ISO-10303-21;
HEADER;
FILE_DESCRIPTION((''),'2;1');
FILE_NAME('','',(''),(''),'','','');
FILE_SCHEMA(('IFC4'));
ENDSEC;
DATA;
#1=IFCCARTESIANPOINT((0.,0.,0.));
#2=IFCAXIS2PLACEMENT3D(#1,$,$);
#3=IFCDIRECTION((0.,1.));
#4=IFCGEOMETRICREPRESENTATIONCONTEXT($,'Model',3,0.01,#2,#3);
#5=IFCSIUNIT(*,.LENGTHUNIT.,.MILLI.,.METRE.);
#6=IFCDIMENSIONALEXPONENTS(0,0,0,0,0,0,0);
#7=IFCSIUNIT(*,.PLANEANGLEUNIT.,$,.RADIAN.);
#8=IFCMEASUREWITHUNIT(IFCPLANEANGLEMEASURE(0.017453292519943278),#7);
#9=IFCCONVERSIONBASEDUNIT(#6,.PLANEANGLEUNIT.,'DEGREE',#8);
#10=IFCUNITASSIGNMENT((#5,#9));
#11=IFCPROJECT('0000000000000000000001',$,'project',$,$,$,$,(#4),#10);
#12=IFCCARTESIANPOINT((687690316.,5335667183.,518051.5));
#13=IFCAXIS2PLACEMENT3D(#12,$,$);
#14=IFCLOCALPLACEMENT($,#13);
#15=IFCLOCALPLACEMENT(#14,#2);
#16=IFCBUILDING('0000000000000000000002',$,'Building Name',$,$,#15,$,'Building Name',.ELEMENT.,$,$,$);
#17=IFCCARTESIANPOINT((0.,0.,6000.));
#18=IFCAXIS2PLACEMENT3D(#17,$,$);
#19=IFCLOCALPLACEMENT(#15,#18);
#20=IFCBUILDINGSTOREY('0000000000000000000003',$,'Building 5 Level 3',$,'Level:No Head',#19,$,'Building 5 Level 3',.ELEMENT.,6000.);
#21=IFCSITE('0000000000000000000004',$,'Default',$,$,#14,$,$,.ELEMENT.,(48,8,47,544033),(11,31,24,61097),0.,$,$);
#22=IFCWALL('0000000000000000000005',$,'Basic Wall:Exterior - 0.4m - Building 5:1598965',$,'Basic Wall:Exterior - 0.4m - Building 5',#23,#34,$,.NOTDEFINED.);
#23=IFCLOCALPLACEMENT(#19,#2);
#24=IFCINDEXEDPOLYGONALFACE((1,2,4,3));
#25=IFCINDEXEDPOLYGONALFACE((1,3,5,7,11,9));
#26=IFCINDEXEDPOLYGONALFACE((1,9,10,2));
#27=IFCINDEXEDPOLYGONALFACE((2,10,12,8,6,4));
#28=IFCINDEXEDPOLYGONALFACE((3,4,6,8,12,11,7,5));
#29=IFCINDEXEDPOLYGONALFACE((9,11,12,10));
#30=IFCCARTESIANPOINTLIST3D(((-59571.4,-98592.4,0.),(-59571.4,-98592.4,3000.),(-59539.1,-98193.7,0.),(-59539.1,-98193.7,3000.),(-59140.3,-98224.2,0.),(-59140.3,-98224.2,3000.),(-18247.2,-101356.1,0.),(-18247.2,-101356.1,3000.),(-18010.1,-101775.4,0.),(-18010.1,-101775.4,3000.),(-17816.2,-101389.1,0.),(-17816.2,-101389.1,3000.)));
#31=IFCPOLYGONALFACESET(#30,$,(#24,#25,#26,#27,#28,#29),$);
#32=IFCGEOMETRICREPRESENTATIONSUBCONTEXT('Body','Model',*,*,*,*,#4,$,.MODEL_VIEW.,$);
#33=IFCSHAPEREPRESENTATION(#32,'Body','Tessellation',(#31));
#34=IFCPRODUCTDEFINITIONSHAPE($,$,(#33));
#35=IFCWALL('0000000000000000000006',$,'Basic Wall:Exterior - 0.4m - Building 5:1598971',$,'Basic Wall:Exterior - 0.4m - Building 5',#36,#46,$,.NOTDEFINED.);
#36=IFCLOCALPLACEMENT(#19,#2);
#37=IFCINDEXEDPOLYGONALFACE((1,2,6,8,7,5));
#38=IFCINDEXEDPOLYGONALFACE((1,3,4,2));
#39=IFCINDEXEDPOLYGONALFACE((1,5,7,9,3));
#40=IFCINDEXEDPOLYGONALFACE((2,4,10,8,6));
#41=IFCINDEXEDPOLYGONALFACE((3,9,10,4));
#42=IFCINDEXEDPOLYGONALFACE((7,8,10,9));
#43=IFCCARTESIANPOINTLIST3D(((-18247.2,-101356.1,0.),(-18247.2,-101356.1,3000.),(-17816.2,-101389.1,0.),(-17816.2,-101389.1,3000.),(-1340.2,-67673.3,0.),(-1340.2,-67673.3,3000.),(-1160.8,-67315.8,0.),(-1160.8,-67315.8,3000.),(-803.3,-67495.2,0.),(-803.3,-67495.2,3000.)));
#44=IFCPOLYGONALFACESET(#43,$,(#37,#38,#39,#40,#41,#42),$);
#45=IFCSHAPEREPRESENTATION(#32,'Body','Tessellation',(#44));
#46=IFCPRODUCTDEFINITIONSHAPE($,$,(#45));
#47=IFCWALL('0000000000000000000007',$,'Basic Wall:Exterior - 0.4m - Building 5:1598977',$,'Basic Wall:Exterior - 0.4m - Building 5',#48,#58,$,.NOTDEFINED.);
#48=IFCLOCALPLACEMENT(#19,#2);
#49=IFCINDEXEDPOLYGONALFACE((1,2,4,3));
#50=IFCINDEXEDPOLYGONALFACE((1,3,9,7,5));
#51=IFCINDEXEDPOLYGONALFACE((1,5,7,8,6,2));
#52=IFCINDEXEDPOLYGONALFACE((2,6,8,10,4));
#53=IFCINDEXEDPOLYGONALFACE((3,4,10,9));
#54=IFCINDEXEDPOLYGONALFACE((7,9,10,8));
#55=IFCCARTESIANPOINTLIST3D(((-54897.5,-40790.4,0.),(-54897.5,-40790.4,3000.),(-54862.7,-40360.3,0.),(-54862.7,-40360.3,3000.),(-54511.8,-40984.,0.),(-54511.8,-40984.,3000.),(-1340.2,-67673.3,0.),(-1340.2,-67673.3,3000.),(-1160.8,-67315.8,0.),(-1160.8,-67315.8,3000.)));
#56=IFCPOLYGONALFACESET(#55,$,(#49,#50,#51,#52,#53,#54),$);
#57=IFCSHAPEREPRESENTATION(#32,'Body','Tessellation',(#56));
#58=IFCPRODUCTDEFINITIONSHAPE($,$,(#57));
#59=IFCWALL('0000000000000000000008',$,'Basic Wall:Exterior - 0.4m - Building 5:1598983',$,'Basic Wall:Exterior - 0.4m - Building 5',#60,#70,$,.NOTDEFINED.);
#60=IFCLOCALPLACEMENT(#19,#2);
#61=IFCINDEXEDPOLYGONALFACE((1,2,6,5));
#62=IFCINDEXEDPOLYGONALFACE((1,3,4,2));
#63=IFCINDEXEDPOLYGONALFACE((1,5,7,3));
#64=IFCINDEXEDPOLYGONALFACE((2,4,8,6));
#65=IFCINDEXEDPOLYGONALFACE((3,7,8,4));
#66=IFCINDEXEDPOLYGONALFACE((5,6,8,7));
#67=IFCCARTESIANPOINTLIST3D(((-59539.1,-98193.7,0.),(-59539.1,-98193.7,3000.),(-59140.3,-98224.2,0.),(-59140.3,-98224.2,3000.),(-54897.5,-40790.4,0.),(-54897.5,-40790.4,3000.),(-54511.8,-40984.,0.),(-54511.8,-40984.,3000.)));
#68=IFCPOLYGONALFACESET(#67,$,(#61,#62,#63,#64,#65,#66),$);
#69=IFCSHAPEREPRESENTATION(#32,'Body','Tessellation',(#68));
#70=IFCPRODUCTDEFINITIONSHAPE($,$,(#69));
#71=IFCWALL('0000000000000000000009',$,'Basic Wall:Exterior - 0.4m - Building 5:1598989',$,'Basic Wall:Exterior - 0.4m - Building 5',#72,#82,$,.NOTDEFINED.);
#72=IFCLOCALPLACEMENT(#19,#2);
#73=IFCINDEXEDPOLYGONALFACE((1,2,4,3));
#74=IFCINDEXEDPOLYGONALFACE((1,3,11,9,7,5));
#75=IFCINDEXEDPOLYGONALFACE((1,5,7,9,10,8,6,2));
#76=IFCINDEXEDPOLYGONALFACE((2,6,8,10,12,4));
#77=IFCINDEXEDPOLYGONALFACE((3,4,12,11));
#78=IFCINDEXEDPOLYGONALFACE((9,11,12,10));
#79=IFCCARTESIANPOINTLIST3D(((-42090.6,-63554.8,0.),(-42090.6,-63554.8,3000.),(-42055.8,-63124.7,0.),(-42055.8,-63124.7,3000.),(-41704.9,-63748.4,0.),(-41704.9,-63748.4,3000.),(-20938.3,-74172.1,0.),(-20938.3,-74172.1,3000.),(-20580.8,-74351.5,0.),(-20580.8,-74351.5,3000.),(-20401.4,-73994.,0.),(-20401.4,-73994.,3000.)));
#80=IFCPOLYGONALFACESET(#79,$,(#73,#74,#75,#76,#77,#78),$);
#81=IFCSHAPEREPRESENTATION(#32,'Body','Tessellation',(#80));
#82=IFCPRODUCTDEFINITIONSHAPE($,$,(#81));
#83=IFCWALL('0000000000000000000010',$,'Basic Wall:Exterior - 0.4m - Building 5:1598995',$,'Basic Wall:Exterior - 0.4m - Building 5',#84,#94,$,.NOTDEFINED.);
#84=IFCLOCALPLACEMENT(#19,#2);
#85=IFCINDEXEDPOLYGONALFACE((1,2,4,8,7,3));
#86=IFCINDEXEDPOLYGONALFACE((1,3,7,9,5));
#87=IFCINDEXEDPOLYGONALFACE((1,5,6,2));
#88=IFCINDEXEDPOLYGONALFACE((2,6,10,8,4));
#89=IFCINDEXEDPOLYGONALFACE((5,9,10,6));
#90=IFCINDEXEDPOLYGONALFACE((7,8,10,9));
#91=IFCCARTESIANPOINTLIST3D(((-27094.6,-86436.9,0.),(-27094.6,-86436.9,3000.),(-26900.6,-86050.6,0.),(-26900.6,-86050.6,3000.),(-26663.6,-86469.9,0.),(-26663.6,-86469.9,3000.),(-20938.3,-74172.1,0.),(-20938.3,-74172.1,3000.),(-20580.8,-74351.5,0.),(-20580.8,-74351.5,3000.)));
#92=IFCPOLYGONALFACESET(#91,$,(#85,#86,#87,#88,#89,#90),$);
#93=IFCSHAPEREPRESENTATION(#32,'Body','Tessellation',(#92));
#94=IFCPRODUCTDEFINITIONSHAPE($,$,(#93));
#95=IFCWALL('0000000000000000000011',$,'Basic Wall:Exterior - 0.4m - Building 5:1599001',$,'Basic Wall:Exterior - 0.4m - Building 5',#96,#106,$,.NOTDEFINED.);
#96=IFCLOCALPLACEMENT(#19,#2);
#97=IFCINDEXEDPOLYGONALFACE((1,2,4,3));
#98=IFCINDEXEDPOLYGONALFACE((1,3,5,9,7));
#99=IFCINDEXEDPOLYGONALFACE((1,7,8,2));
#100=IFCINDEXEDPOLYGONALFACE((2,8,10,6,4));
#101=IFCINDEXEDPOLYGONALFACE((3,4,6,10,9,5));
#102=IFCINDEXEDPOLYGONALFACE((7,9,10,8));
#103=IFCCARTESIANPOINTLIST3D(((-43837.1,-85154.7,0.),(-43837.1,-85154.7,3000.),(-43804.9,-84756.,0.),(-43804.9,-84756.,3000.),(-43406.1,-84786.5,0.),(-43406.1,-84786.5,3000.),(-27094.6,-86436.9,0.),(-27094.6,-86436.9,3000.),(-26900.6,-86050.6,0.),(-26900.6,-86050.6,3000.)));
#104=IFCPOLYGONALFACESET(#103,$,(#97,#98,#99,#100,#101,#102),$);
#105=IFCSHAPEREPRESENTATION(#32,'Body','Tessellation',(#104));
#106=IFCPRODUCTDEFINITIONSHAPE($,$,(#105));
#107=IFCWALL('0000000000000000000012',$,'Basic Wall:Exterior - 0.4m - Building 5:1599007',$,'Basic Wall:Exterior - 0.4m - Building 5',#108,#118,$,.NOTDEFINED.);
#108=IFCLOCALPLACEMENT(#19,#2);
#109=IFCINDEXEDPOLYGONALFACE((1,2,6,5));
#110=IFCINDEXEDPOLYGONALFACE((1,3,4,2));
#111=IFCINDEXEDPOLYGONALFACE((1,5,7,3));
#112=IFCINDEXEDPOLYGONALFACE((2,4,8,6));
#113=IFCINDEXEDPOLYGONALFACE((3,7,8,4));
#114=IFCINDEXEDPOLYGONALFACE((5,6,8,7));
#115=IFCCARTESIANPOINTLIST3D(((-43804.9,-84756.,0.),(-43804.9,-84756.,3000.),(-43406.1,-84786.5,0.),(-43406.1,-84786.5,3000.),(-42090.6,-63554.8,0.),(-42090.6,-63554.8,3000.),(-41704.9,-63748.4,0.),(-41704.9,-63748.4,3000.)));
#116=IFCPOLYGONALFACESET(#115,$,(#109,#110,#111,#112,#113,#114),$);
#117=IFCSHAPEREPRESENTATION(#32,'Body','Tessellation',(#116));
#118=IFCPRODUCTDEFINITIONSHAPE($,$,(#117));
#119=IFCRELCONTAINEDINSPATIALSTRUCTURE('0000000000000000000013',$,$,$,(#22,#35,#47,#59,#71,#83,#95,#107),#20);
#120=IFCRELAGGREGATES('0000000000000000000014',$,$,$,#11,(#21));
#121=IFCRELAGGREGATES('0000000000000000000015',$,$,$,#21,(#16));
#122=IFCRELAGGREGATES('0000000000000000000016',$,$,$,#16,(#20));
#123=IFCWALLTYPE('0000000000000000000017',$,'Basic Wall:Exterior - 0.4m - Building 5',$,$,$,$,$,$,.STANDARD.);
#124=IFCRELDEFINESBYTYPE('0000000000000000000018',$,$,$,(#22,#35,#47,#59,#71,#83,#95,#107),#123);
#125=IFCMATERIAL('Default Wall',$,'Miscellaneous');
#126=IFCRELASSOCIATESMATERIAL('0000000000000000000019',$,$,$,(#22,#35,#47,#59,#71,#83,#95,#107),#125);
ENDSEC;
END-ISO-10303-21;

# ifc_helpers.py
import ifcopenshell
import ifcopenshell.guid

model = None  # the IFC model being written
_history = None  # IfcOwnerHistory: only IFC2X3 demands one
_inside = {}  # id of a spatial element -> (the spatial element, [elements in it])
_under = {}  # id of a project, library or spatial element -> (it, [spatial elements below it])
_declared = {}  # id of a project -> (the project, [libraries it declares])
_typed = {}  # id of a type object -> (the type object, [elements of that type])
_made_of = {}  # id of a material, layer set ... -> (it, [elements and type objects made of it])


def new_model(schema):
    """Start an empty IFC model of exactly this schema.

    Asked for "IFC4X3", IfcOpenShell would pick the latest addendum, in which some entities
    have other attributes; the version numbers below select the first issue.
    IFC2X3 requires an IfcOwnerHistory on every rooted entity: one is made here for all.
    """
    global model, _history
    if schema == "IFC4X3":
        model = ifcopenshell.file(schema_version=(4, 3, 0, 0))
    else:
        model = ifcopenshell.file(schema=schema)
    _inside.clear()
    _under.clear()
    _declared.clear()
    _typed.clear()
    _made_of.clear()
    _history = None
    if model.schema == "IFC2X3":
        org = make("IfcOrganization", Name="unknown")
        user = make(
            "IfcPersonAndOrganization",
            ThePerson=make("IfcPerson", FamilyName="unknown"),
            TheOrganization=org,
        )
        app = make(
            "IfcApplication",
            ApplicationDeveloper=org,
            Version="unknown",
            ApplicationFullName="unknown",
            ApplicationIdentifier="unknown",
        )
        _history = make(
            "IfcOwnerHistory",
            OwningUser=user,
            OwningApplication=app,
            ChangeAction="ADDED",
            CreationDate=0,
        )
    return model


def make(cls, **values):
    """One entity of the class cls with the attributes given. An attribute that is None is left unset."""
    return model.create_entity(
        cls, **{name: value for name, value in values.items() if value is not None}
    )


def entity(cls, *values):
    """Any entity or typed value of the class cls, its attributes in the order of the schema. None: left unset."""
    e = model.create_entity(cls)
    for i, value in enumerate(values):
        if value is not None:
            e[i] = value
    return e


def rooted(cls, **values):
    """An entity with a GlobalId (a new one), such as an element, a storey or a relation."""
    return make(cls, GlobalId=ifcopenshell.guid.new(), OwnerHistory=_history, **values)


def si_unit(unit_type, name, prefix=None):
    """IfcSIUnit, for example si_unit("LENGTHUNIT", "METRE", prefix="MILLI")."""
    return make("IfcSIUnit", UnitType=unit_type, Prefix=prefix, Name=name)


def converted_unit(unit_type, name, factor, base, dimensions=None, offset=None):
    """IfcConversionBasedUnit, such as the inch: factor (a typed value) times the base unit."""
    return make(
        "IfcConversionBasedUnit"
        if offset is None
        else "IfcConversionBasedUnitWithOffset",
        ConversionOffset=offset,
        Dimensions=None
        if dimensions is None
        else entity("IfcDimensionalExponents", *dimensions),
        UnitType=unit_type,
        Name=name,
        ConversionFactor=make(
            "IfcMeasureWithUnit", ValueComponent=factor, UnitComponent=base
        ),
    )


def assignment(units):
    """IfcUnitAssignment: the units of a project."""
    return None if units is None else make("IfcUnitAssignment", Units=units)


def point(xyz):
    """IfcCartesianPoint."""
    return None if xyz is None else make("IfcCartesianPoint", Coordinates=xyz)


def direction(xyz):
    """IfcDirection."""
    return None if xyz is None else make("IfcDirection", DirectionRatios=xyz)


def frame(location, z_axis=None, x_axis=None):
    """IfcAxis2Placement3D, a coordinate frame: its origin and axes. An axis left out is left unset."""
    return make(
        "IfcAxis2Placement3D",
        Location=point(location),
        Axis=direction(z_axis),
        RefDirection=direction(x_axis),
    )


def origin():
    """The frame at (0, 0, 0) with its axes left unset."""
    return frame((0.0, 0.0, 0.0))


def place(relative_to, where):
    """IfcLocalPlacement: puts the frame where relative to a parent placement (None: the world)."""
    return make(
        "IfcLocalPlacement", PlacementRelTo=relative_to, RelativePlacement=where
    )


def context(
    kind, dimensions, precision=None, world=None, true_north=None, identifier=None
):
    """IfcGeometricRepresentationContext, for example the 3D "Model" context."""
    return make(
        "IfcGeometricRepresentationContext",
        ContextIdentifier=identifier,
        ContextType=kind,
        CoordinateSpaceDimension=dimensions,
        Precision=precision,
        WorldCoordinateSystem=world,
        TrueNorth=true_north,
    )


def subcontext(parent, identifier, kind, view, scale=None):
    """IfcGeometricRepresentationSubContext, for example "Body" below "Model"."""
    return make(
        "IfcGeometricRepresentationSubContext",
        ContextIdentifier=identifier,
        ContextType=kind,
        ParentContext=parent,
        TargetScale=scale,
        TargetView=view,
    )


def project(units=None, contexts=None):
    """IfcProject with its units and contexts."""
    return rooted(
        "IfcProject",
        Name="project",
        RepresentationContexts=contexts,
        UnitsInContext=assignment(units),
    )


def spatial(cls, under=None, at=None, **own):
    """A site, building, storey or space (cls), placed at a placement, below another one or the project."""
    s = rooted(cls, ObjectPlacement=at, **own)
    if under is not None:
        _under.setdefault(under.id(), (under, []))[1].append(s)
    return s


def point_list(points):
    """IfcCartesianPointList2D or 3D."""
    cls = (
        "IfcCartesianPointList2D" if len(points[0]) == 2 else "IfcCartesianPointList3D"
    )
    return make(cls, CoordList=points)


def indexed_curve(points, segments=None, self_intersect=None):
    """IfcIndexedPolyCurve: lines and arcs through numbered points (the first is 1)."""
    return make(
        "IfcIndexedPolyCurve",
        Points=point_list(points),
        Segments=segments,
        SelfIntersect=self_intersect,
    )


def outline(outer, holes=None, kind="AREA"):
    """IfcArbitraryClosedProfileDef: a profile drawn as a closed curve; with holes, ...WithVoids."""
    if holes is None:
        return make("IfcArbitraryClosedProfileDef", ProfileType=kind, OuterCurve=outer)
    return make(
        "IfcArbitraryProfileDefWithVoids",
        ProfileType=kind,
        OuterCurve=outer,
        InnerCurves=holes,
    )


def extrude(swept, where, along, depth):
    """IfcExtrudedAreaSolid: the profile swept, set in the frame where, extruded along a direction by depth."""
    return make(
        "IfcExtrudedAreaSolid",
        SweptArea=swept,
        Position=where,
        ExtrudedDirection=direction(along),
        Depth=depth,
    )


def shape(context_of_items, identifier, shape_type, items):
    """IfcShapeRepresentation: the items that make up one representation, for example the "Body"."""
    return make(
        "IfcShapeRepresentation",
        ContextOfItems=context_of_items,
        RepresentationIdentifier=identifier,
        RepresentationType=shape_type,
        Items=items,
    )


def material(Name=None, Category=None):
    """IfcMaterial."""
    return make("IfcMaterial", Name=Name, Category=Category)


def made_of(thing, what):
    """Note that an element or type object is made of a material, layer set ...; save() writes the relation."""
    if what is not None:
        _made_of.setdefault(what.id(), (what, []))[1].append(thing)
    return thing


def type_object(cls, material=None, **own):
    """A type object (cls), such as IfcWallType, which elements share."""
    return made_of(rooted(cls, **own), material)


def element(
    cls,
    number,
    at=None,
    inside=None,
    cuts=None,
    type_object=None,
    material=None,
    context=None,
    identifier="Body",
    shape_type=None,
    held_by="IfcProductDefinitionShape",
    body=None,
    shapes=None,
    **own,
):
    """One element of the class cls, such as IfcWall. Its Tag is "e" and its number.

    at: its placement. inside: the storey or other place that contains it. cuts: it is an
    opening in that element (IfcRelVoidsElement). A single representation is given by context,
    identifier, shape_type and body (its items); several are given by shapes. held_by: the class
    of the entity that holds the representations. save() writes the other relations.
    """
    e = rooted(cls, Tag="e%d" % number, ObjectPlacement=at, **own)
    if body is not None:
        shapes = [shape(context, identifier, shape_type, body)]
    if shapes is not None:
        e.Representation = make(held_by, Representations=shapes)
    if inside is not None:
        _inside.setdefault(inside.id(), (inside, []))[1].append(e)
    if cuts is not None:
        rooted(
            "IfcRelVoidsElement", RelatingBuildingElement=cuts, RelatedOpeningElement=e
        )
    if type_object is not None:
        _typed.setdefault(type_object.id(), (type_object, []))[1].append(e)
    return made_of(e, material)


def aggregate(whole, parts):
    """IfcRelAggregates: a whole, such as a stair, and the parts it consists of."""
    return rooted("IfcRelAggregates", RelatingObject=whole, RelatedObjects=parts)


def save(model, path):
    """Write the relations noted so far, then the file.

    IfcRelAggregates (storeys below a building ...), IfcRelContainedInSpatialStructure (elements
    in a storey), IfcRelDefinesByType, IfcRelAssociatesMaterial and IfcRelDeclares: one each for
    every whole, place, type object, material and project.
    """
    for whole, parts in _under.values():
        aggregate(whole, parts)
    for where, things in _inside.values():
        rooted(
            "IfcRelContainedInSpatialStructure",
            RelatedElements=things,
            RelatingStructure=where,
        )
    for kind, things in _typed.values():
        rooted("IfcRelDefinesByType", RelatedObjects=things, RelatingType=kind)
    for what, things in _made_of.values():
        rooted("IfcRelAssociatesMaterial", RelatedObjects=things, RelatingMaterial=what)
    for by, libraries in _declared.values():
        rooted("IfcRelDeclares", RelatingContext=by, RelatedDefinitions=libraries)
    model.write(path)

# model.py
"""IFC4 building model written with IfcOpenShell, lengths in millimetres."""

from ifc_helpers import new_model, entity, si_unit, converted_unit, direction, frame, origin, place, context, subcontext, project, spatial, indexed_curve, outline, extrude, material, type_object, element, save


model = new_model("IFC4")

# Units and contexts
model_context = context("Model", 3, precision=0.01, world=origin(), true_north=direction((0.0, 1.0)))
body_context = subcontext(model_context, "Body", "Model", "MODEL_VIEW")
ifc_project = project(units=[si_unit("LENGTHUNIT", "METRE", prefix="MILLI"), converted_unit("PLANEANGLEUNIT", "DEGREE", entity("IfcPlaneAngleMeasure", 0.017453292519943278), si_unit("PLANEANGLEUNIT", "RADIAN"), dimensions=[0, 0, 0, 0, 0, 0, 0])], contexts=[model_context])

# Site, building, storey
site_placement = place(None, frame((687690316.0, 5335667183.0, 518051.5)))
site = spatial("IfcSite", under=ifc_project, at=site_placement, Name="Default", CompositionType="ELEMENT", RefLatitude=(48, 8, 47, 544033), RefLongitude=(11, 31, 24, 61097), RefElevation=0.0)
building_placement = place(site_placement, origin())
building = spatial("IfcBuilding", under=site, at=building_placement, Name="Building Name", LongName="Building Name", CompositionType="ELEMENT")
storey_placement = place(building_placement, frame((0.0, 0.0, 6000.0)))
storey = spatial("IfcBuildingStorey", under=building, at=storey_placement, Name="Building 5 Level 3", ObjectType="Level:No Head", LongName="Building 5 Level 3", CompositionType="ELEMENT", Elevation=6000.0)

# Walls
ifc_material_1 = material(Name="Default Wall", Category="Miscellaneous")
wall_type = type_object("IfcWallType", Name="Basic Wall:Exterior - 0.4m - Building 5", PredefinedType="STANDARD")
wall_1_placement = place(storey_placement, frame((-59556.1, -98393.0, 0.0), z_axis=(0.0, 0.0, 1.0), x_axis=(0.99708, -0.076363, 0.0)))
element("IfcWall", 1, at=wall_1_placement, inside=storey, type_object=wall_type, material=ifc_material_1, Name="Basic Wall:Exterior - 0.4m - Building 5:1598965", ObjectType="Basic Wall:Exterior - 0.4m - Building 5", PredefinedType="NOTDEFINED", context=body_context, shape_type="SweptSolid", body=[
    extrude(outline(indexed_curve([(41683.0, -200.0), (41846.9, 200.0), (41414.6, 200.0), (401.7, 200.0), (1.7, 200.0), (0.0, -200.0), (41683.0, -200.0)], self_intersect=False)), origin(), (0.0, 0.0, 1.0), 3000.0),
])
wall_2_placement = place(storey_placement, frame((-18068.4, -101445.8, 0.0), z_axis=(0.0, 0.0, 1.0), x_axis=(0.448604, 0.893731, 0.0)))
element("IfcWall", 2, at=wall_2_placement, inside=storey, type_object=wall_type, material=ifc_material_1, Name="Basic Wall:Exterior - 0.4m - Building 5:1598971", ObjectType="Basic Wall:Exterior - 0.4m - Building 5", PredefinedType="NOTDEFINED", context=body_context, shape_type="SweptSolid", body=[
    extrude(outline(indexed_curve([(38087.9, -200.0), (38087.9, 200.0), (37687.9, 200.0), (0.0, 200.0), (163.8, -200.0), (38087.9, -200.0)], self_intersect=False)), origin(), (0.0, 0.0, 1.0), 3000.0),
])
wall_3_placement = place(storey_placement, frame((-1250.5, -67494.5, 0.0), z_axis=(0.0, 0.0, 1.0), x_axis=(-0.893731, 0.448604, 0.0)))
element("IfcWall", 3, at=wall_3_placement, inside=storey, type_object=wall_type, material=ifc_material_1, Name="Basic Wall:Exterior - 0.4m - Building 5:1598977", ObjectType="Basic Wall:Exterior - 0.4m - Building 5", PredefinedType="NOTDEFINED", context=body_context, shape_type="SweptSolid", body=[
    extrude(outline(indexed_curve([(60087.4, -200.0), (59925.5, 200.0), (59494.0, 200.0), (0.0, 200.0), (0.0, -200.0), (60087.4, -200.0)], self_intersect=False)), origin(), (0.0, 0.0, 1.0), 3000.0),
])
wall_4_placement = place(storey_placement, frame((-54698.1, -40806.5, 0.0), z_axis=(0.0, 0.0, 1.0), x_axis=(-0.080597, -0.996747, 0.0)))
element("IfcWall", 4, at=wall_4_placement, inside=storey, type_object=wall_type, material=ifc_material_1, Name="Basic Wall:Exterior - 0.4m - Building 5:1598983", ObjectType="Basic Wall:Exterior - 0.4m - Building 5", PredefinedType="NOTDEFINED", context=body_context, shape_type="SweptSolid", body=[
    extrude(outline(indexed_curve([(57590.6, -200.0), (57588.9, 200.0), (161.9, 200.0), (0.0, -200.0), (57590.6, -200.0)], self_intersect=False)), origin(), (0.0, 0.0, 1.0), 3000.0),
])
wall_5_placement = place(storey_placement, frame((-42145.5, -63303.4, 0.0), z_axis=(0.0, 0.0, 1.0), x_axis=(0.893731, -0.448604, 0.0)))
element("IfcWall", 5, at=wall_5_placement, inside=storey, type_object=wall_type, material=ifc_material_1, Name="Basic Wall:Exterior - 0.4m - Building 5:1598989", ObjectType="Basic Wall:Exterior - 0.4m - Building 5", PredefinedType="NOTDEFINED", context=body_context, shape_type="SweptSolid", body=[
    extrude(outline(indexed_curve([(24229.3, -200.0), (24229.3, 200.0), (0.0, 200.0), (161.9, -200.0), (593.4, -200.0), (23829.3, -200.0), (24229.3, -200.0)], self_intersect=False)), origin(), (0.0, 0.0, 1.0), 3000.0),
])
wall_6_placement = place(storey_placement, frame((-20759.5, -74261.8, 0.0), z_axis=(0.0, 0.0, 1.0), x_axis=(-0.448604, -0.893731, 0.0)))
element("IfcWall", 6, at=wall_6_placement, inside=storey, type_object=wall_type, material=ifc_material_1, Name="Basic Wall:Exterior - 0.4m - Building 5:1598995", ObjectType="Basic Wall:Exterior - 0.4m - Building 5", PredefinedType="NOTDEFINED", context=body_context, shape_type="SweptSolid", body=[
    extrude(outline(indexed_curve([(13723.2, -200.0), (13559.3, 200.0), (0.0, 200.0), (0.0, -200.0), (13290.9, -200.0), (13723.2, -200.0)], self_intersect=False)), origin(), (0.0, 0.0, 1.0), 3000.0),
])
wall_7_placement = place(storey_placement, frame((-26915.9, -86250.0, 0.0), z_axis=(0.0, 0.0, 1.0), x_axis=(-0.99708, 0.076363, 0.0)))
element("IfcWall", 7, at=wall_7_placement, inside=storey, type_object=wall_type, material=ifc_material_1, Name="Basic Wall:Exterior - 0.4m - Building 5:1599001", ObjectType="Basic Wall:Exterior - 0.4m - Building 5", PredefinedType="NOTDEFINED", context=body_context, shape_type="SweptSolid", body=[
    extrude(outline(indexed_curve([(16953.8, -200.0), (16955.5, 200.0), (163.8, 200.0), (0.0, -200.0), (16553.8, -200.0), (16953.8, -200.0)], self_intersect=False)), origin(), (0.0, 0.0, 1.0), 3000.0),
])
wall_8_placement = place(storey_placement, frame((-43605.6, -84772.1, 0.0), z_axis=(0.0, 0.0, 1.0), x_axis=(0.080597, 0.996747, 0.0)))
element("IfcWall", 8, at=wall_8_placement, inside=storey, type_object=wall_type, material=ifc_material_1, Name="Basic Wall:Exterior - 0.4m - Building 5:1599007", ObjectType="Basic Wall:Exterior - 0.4m - Building 5", PredefinedType="NOTDEFINED", context=body_context, shape_type="SweptSolid", body=[
    extrude(outline(indexed_curve([(21108.5, -200.0), (21270.4, 200.0), (0.0, 200.0), (1.7, -200.0), (21108.5, -200.0)], self_intersect=False)), origin(), (0.0, 0.0, 1.0), 3000.0),
])

save(model, "model.ifc")
